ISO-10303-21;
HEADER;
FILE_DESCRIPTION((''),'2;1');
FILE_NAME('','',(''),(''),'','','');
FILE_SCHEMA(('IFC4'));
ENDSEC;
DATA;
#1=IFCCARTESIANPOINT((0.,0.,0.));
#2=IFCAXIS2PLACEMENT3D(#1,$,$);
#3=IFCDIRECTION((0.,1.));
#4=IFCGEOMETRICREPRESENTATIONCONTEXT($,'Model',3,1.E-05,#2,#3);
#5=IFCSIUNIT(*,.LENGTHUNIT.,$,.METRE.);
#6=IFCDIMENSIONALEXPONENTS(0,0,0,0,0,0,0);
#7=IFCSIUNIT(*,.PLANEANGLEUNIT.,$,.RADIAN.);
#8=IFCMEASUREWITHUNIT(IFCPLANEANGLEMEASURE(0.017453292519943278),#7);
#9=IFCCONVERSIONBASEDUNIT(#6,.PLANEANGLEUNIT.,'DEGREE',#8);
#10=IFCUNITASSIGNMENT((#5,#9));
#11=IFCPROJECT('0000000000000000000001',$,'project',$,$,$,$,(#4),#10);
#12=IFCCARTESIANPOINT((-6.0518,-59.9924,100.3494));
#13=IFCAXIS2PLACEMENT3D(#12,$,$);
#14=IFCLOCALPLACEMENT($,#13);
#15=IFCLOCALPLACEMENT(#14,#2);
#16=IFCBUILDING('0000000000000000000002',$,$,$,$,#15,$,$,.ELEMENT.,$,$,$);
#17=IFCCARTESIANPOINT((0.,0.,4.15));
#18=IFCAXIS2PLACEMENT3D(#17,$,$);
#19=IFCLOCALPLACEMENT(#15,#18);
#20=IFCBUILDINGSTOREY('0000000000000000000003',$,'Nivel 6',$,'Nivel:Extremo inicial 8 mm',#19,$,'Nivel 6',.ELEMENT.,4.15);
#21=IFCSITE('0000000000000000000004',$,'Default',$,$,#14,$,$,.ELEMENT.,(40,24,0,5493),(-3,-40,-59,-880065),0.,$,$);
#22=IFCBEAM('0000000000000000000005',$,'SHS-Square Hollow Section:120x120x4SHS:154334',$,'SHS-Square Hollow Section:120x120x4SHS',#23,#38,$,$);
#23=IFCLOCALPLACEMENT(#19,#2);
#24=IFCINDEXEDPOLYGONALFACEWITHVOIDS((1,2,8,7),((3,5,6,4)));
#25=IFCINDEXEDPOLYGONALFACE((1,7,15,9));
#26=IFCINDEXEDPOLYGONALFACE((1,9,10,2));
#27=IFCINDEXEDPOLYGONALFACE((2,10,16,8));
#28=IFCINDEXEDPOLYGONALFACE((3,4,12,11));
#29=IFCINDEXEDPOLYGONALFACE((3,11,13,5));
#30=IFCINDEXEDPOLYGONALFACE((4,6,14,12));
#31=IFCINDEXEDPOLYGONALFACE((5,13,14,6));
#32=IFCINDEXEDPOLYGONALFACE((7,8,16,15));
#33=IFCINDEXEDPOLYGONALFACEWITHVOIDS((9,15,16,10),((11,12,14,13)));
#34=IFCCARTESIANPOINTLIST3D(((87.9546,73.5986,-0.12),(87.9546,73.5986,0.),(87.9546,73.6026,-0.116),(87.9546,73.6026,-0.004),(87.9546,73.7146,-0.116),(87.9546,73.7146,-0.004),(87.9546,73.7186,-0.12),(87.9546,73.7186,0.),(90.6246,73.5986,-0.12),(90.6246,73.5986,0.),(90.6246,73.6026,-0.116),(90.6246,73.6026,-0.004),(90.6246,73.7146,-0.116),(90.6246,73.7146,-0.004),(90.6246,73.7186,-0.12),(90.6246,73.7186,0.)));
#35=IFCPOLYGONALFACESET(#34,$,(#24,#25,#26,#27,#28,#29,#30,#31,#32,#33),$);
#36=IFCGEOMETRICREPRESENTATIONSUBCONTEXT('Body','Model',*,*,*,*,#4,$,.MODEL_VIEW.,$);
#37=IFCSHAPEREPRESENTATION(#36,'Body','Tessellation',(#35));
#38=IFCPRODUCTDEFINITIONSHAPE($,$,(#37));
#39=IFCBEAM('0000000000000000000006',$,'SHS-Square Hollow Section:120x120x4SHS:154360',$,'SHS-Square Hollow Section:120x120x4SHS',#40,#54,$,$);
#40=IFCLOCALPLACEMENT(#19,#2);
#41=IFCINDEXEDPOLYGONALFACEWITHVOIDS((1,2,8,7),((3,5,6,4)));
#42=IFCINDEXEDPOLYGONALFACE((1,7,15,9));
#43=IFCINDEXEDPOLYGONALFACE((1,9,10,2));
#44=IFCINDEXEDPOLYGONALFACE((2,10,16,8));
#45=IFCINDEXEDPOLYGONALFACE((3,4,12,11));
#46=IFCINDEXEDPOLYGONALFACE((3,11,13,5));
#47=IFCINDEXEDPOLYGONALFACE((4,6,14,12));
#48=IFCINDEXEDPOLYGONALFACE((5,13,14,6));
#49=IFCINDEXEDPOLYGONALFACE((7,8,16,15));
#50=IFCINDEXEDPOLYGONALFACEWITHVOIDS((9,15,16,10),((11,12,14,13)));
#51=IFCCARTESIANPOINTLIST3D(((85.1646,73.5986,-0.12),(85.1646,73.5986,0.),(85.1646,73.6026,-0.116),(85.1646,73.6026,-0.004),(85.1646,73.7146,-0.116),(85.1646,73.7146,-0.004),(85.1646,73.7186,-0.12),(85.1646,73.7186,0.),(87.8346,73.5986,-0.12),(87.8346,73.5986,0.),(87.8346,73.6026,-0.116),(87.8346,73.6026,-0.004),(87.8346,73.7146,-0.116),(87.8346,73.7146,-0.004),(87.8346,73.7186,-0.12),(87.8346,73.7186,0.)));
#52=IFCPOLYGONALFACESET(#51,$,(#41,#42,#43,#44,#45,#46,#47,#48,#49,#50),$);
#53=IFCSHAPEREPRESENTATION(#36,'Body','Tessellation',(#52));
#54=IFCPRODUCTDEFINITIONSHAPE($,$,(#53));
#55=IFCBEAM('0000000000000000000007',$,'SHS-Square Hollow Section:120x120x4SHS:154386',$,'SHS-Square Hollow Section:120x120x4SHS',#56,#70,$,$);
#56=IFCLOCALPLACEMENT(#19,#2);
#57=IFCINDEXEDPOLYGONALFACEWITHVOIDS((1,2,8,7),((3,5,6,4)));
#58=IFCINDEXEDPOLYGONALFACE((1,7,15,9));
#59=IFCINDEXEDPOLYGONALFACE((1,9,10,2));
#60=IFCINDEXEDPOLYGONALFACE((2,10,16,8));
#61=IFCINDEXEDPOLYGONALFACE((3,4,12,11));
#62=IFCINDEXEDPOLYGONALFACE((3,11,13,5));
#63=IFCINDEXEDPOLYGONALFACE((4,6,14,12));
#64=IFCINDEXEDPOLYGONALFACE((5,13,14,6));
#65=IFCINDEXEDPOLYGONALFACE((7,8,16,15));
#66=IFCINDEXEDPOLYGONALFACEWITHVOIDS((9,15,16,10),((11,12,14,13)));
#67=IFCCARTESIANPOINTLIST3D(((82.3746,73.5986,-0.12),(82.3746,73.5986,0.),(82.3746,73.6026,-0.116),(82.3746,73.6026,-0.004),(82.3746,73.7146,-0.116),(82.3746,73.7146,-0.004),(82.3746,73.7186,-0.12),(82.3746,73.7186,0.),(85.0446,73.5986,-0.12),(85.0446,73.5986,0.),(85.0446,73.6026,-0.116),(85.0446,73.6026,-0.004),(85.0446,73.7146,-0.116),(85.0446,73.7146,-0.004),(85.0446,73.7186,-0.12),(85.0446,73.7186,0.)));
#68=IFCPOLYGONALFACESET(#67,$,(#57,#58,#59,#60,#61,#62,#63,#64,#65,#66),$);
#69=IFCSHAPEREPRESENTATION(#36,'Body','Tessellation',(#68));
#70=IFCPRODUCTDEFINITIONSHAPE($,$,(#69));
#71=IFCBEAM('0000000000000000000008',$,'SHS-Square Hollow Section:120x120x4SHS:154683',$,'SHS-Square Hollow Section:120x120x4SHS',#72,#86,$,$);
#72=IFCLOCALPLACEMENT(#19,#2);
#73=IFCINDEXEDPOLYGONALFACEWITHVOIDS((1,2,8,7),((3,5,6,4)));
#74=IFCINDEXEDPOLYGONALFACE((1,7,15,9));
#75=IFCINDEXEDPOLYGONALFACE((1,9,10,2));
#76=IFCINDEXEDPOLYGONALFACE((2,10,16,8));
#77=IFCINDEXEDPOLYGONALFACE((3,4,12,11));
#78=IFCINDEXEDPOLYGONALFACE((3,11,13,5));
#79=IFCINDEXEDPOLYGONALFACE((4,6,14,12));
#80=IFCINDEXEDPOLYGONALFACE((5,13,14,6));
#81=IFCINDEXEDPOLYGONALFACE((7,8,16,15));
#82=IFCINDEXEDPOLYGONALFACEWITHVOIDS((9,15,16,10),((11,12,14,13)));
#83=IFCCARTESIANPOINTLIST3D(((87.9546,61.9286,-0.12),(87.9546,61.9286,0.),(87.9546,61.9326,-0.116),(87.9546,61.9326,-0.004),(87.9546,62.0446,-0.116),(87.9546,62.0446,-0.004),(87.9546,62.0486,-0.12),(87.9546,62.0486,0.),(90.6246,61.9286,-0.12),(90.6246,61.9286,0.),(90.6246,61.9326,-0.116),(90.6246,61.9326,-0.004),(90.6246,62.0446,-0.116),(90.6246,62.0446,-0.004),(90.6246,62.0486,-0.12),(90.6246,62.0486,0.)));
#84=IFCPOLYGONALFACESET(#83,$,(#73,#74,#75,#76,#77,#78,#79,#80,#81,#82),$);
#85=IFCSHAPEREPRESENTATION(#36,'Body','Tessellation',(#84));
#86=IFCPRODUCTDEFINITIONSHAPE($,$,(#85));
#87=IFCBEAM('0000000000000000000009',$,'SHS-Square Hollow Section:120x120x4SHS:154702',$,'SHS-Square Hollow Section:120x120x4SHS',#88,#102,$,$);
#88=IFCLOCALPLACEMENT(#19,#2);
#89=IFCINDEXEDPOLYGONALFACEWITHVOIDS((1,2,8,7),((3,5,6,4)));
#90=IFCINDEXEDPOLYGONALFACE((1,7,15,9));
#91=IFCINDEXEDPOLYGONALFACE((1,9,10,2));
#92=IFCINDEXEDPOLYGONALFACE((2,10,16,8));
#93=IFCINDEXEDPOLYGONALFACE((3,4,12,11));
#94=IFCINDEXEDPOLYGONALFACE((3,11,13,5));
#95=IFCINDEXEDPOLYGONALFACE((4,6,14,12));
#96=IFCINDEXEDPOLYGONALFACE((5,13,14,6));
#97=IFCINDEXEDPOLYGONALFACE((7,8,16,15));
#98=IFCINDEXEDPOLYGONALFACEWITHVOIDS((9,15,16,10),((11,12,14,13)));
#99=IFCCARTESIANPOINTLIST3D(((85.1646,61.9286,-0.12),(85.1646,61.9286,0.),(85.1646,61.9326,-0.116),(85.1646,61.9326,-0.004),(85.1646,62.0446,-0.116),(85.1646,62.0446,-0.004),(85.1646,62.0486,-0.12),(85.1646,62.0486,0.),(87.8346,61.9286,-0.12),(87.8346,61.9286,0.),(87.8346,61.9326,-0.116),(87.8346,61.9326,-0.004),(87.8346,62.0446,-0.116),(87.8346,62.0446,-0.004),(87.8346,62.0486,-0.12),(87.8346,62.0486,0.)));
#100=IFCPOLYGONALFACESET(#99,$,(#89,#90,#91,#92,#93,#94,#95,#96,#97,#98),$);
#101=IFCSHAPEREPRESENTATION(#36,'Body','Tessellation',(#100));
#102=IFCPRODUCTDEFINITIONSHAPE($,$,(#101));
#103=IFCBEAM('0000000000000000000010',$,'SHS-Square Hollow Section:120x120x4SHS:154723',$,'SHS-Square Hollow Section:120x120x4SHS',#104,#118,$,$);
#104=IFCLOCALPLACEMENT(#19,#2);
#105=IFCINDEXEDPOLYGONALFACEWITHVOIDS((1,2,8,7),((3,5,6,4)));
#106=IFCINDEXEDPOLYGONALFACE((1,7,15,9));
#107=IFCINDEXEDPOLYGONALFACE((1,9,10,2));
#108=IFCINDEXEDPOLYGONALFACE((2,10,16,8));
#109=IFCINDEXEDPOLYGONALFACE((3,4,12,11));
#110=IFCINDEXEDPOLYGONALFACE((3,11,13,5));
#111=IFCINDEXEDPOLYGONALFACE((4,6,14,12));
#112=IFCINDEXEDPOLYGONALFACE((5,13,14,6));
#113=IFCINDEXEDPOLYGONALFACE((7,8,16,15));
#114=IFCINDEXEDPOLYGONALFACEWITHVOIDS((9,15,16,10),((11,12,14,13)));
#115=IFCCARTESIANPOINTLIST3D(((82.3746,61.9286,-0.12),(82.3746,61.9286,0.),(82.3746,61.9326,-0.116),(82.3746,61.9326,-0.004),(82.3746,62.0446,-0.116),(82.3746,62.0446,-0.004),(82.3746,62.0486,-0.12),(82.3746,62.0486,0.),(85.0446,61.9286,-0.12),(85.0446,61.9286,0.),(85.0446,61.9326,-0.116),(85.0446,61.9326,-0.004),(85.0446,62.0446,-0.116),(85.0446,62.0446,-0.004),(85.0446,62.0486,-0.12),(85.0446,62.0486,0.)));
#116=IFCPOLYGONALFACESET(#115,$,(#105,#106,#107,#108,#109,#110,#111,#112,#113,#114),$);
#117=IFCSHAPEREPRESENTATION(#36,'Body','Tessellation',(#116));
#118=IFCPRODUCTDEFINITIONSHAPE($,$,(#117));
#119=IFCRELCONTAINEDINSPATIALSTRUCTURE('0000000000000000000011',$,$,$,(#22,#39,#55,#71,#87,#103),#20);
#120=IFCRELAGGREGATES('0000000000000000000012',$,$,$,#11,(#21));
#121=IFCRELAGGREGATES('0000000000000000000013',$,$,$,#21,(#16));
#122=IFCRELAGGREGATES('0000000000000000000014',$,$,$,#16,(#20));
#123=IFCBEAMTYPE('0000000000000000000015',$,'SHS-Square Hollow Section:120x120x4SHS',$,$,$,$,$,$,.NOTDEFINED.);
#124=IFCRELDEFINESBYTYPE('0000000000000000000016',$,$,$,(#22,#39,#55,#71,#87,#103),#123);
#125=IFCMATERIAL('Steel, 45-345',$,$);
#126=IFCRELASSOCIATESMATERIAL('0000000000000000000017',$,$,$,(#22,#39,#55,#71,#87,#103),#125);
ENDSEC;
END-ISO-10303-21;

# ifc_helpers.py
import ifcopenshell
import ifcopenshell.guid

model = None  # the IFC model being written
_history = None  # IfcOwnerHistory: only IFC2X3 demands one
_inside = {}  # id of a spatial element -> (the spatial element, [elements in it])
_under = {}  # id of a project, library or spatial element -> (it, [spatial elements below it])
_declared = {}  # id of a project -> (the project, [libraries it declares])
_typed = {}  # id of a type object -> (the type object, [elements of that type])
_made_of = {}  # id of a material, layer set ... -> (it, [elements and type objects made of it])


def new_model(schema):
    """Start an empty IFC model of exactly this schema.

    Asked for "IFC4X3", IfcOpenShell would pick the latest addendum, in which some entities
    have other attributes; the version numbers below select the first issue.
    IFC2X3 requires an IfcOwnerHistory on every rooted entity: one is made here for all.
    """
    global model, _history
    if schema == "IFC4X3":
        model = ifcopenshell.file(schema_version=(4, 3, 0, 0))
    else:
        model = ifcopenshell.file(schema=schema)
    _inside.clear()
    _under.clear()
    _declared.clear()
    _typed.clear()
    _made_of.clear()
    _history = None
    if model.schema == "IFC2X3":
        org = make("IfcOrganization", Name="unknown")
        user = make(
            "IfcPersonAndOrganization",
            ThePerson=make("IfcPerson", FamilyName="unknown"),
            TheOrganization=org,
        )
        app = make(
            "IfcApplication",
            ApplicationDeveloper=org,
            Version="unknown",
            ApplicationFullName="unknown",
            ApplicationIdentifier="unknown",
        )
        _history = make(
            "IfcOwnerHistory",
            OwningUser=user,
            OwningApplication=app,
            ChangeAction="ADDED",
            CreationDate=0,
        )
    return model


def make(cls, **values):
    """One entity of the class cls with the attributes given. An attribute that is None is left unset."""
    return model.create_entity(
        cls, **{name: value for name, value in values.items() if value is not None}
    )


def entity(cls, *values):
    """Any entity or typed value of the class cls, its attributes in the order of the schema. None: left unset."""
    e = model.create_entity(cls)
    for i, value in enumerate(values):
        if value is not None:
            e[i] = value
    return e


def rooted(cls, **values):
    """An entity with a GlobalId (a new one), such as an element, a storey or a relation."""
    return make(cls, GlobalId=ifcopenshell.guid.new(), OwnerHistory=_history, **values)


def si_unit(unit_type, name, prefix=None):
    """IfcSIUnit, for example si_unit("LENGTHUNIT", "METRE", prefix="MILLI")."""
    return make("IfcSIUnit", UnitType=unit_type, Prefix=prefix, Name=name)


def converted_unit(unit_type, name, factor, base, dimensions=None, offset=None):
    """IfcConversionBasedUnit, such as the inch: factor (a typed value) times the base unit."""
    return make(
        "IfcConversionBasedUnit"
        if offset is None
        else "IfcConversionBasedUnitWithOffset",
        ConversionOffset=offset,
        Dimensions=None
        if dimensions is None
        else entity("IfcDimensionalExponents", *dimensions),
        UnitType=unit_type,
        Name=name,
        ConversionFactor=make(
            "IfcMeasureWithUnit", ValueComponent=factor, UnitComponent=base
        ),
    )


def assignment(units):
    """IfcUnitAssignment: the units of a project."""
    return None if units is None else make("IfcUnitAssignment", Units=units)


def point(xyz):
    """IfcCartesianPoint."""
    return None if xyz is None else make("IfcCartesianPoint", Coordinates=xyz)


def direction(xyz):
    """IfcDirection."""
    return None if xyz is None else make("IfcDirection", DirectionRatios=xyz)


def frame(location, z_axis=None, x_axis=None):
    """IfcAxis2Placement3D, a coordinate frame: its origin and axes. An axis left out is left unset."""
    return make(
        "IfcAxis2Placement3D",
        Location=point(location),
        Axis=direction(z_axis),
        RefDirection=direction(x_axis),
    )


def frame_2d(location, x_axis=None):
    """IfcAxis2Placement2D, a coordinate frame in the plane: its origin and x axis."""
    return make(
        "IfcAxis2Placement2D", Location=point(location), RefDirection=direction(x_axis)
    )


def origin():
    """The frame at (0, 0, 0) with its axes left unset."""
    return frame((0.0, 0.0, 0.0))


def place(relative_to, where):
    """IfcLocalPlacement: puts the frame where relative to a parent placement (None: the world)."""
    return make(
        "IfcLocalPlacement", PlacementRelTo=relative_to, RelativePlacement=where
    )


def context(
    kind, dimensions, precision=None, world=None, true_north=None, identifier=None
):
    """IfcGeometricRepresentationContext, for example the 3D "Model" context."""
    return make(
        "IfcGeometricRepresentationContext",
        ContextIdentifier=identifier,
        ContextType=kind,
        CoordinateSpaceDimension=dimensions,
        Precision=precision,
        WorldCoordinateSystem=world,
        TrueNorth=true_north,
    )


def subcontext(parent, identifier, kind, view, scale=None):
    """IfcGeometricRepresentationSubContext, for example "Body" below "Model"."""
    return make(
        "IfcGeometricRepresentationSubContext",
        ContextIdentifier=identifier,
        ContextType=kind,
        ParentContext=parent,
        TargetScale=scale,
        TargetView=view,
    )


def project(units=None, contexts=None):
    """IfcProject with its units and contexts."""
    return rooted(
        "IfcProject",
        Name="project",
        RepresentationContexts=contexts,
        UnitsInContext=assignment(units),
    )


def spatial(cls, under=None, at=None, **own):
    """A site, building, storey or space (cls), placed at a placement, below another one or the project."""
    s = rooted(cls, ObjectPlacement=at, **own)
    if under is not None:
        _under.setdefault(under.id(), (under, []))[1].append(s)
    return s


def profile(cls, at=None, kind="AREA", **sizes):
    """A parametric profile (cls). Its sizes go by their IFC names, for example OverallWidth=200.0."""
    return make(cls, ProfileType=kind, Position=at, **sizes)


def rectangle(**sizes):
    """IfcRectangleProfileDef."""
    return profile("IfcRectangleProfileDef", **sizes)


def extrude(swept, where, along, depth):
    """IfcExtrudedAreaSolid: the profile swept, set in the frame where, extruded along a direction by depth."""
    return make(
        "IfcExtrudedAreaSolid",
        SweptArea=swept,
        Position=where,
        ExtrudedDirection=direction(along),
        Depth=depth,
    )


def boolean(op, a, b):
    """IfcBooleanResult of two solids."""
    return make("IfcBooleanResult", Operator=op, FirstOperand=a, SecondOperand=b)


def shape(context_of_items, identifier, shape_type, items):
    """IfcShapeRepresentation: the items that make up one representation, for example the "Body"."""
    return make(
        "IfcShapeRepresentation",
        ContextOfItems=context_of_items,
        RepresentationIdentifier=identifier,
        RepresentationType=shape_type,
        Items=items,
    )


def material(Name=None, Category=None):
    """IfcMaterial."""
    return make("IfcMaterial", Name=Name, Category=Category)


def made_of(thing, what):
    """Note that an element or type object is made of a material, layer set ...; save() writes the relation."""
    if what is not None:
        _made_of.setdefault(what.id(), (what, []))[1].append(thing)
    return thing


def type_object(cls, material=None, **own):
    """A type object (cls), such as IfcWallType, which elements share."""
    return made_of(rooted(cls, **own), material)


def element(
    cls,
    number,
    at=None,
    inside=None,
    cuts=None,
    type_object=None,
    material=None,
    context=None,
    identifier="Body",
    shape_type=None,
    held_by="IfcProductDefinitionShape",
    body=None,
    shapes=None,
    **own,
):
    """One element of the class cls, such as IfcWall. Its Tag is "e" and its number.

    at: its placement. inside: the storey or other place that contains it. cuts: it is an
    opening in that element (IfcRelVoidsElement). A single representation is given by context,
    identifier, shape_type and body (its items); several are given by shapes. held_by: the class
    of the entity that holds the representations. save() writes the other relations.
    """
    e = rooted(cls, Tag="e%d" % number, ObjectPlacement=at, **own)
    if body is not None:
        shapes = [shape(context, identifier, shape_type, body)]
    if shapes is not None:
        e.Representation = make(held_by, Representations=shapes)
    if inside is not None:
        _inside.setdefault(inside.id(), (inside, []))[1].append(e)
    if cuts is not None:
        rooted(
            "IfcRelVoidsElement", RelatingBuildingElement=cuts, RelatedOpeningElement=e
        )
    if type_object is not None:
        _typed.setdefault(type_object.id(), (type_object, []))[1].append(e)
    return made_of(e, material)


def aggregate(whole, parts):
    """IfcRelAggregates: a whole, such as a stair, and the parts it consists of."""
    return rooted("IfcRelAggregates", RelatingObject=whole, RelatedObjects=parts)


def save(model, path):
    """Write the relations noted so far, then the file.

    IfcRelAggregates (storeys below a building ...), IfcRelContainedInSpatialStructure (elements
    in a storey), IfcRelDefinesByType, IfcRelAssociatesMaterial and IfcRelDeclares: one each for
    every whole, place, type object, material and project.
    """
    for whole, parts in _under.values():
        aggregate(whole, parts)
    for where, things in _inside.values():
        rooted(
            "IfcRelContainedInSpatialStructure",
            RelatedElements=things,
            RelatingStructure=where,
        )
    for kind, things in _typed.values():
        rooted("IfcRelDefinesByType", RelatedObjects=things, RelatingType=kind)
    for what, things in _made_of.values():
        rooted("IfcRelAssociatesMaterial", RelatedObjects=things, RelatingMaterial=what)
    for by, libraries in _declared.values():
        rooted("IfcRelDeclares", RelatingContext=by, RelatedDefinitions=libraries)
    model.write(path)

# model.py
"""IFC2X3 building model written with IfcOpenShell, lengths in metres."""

from ifc_helpers import new_model, entity, si_unit, converted_unit, direction, frame, frame_2d, origin, place, context, subcontext, project, spatial, rectangle, extrude, boolean, material, type_object, element, save


model = new_model("IFC2X3")

# Units and contexts
model_context = context("Model", 3, precision=1e-05, world=origin(), true_north=direction((0.0, 1.0)))
body_context = subcontext(model_context, "Body", "Model", "MODEL_VIEW")
ifc_project = project(units=[si_unit("LENGTHUNIT", "METRE"), converted_unit("PLANEANGLEUNIT", "DEGREE", entity("IfcPlaneAngleMeasure", 0.017453292519943278), si_unit("PLANEANGLEUNIT", "RADIAN"), dimensions=[0, 0, 0, 0, 0, 0, 0])], contexts=[model_context])

# Site, building, storey
site_placement = place(None, frame((-6.0518, -59.9924, 100.3494)))
site = spatial("IfcSite", under=ifc_project, at=site_placement, Name="Default", CompositionType="ELEMENT", RefLatitude=(40, 24, 0, 5493), RefLongitude=(-3, -40, -59, -880065), RefElevation=0.0)
building_placement = place(site_placement, origin())
building = spatial("IfcBuilding", under=site, at=building_placement, CompositionType="ELEMENT")
storey_placement = place(building_placement, frame((0.0, 0.0, 4.15)))
storey = spatial("IfcBuildingStorey", under=building, at=storey_placement, Name="Nivel 6", ObjectType="Nivel:Extremo inicial 8 mm", LongName="Nivel 6", CompositionType="ELEMENT", Elevation=4.15)

# Beams
ifc_material_1 = material(Name="Steel, 45-345")
beam_type = type_object("IfcBeamType", Name="SHS-Square Hollow Section:120x120x4SHS", PredefinedType="NOTDEFINED")
beam_1_placement = place(storey_placement, frame((90.6846, 73.6586, 0.0), z_axis=(0.0, 0.0, 1.0), x_axis=(-1.0, 0.0, 0.0)))
element("IfcBeam", 1, at=beam_1_placement, inside=storey, type_object=beam_type, material=ifc_material_1, Name="SHS-Square Hollow Section:120x120x4SHS:154334", ObjectType="SHS-Square Hollow Section:120x120x4SHS", context=body_context, shape_type="SweptSolid", body=[
    boolean("DIFFERENCE", extrude(rectangle(XDim=0.12, YDim=0.12, at=frame_2d((0.0, 0.0), x_axis=(1.0, 0.0))), frame((0.06, 0.0, -0.06), z_axis=(1.0, 0.0, 0.0), x_axis=(0.0, 0.0, -1.0)), (0.0, 0.0, 1.0), 2.67), extrude(rectangle(XDim=0.112, YDim=0.112, at=frame_2d((0.0, 0.0), x_axis=(0.0, 1.0))), frame((2.73, 0.0, -0.06), z_axis=(-1.0, 0.0, 0.0), x_axis=(0.0, 1.0, 0.0)), (0.0, 0.0, 1.0), 2.67)),
])
beam_2_placement = place(storey_placement, frame((87.8946, 73.6586, 0.0), z_axis=(0.0, 0.0, 1.0), x_axis=(-1.0, 0.0, 0.0)))
element("IfcBeam", 2, at=beam_2_placement, inside=storey, type_object=beam_type, material=ifc_material_1, Name="SHS-Square Hollow Section:120x120x4SHS:154360", ObjectType="SHS-Square Hollow Section:120x120x4SHS", context=body_context, shape_type="SweptSolid", body=[
    boolean("DIFFERENCE", extrude(rectangle(XDim=0.12, YDim=0.12, at=frame_2d((0.0, 0.0), x_axis=(1.0, 0.0))), frame((0.06, 0.0, -0.06), z_axis=(1.0, 0.0, 0.0), x_axis=(0.0, 0.0, -1.0)), (0.0, 0.0, 1.0), 2.67), extrude(rectangle(XDim=0.112, YDim=0.112, at=frame_2d((0.0, 0.0), x_axis=(0.0, 1.0))), frame((2.73, 0.0, -0.06), z_axis=(-1.0, 0.0, 0.0), x_axis=(0.0, 1.0, 0.0)), (0.0, 0.0, 1.0), 2.67)),
])
beam_3_placement = place(storey_placement, frame((85.1046, 73.6586, 0.0), z_axis=(0.0, 0.0, 1.0), x_axis=(-1.0, 0.0, 0.0)))
element("IfcBeam", 3, at=beam_3_placement, inside=storey, type_object=beam_type, material=ifc_material_1, Name="SHS-Square Hollow Section:120x120x4SHS:154386", ObjectType="SHS-Square Hollow Section:120x120x4SHS", context=body_context, shape_type="SweptSolid", body=[
    boolean("DIFFERENCE", extrude(rectangle(XDim=0.12, YDim=0.12, at=frame_2d((0.0, 0.0), x_axis=(1.0, 0.0))), frame((0.06, 0.0, -0.06), z_axis=(1.0, 0.0, 0.0), x_axis=(0.0, 0.0, -1.0)), (0.0, 0.0, 1.0), 2.67), extrude(rectangle(XDim=0.112, YDim=0.112, at=frame_2d((0.0, 0.0), x_axis=(0.0, 1.0))), frame((2.73, 0.0, -0.06), z_axis=(-1.0, 0.0, 0.0), x_axis=(0.0, 1.0, 0.0)), (0.0, 0.0, 1.0), 2.67)),
])
beam_4_placement = place(storey_placement, frame((90.6846, 61.9886, 0.0), z_axis=(0.0, 0.0, 1.0), x_axis=(-1.0, 0.0, 0.0)))
element("IfcBeam", 4, at=beam_4_placement, inside=storey, type_object=beam_type, material=ifc_material_1, Name="SHS-Square Hollow Section:120x120x4SHS:154683", ObjectType="SHS-Square Hollow Section:120x120x4SHS", context=body_context, shape_type="SweptSolid", body=[
    boolean("DIFFERENCE", extrude(rectangle(XDim=0.12, YDim=0.12, at=frame_2d((0.0, 0.0), x_axis=(1.0, 0.0))), frame((0.06, 0.0, -0.06), z_axis=(1.0, 0.0, 0.0), x_axis=(0.0, 0.0, -1.0)), (0.0, 0.0, 1.0), 2.67), extrude(rectangle(XDim=0.112, YDim=0.112, at=frame_2d((0.0, 0.0), x_axis=(0.0, 1.0))), frame((2.73, 0.0, -0.06), z_axis=(-1.0, 0.0, 0.0), x_axis=(0.0, 1.0, 0.0)), (0.0, 0.0, 1.0), 2.67)),
])
beam_5_placement = place(storey_placement, frame((87.8946, 61.9886, 0.0), z_axis=(0.0, 0.0, 1.0), x_axis=(-1.0, 0.0, 0.0)))
element("IfcBeam", 5, at=beam_5_placement, inside=storey, type_object=beam_type, material=ifc_material_1, Name="SHS-Square Hollow Section:120x120x4SHS:154702", ObjectType="SHS-Square Hollow Section:120x120x4SHS", context=body_context, shape_type="SweptSolid", body=[
    boolean("DIFFERENCE", extrude(rectangle(XDim=0.12, YDim=0.12, at=frame_2d((0.0, 0.0), x_axis=(1.0, 0.0))), frame((0.06, 0.0, -0.06), z_axis=(1.0, 0.0, 0.0), x_axis=(0.0, 0.0, -1.0)), (0.0, 0.0, 1.0), 2.67), extrude(rectangle(XDim=0.112, YDim=0.112, at=frame_2d((0.0, 0.0), x_axis=(0.0, 1.0))), frame((2.73, 0.0, -0.06), z_axis=(-1.0, 0.0, 0.0), x_axis=(0.0, 1.0, 0.0)), (0.0, 0.0, 1.0), 2.67)),
])
beam_6_placement = place(storey_placement, frame((85.1046, 61.9886, 0.0), z_axis=(0.0, 0.0, 1.0), x_axis=(-1.0, 0.0, 0.0)))
element("IfcBeam", 6, at=beam_6_placement, inside=storey, type_object=beam_type, material=ifc_material_1, Name="SHS-Square Hollow Section:120x120x4SHS:154723", ObjectType="SHS-Square Hollow Section:120x120x4SHS", context=body_context, shape_type="SweptSolid", body=[
    boolean("DIFFERENCE", extrude(rectangle(XDim=0.12, YDim=0.12, at=frame_2d((0.0, 0.0), x_axis=(1.0, 0.0))), frame((0.06, 0.0, -0.06), z_axis=(1.0, 0.0, 0.0), x_axis=(0.0, 0.0, -1.0)), (0.0, 0.0, 1.0), 2.67), extrude(rectangle(XDim=0.112, YDim=0.112, at=frame_2d((0.0, 0.0), x_axis=(0.0, 1.0))), frame((2.73, 0.0, -0.06), z_axis=(-1.0, 0.0, 0.0), x_axis=(0.0, 1.0, 0.0)), (0.0, 0.0, 1.0), 2.67)),
])

save(model, "model.ifc")
